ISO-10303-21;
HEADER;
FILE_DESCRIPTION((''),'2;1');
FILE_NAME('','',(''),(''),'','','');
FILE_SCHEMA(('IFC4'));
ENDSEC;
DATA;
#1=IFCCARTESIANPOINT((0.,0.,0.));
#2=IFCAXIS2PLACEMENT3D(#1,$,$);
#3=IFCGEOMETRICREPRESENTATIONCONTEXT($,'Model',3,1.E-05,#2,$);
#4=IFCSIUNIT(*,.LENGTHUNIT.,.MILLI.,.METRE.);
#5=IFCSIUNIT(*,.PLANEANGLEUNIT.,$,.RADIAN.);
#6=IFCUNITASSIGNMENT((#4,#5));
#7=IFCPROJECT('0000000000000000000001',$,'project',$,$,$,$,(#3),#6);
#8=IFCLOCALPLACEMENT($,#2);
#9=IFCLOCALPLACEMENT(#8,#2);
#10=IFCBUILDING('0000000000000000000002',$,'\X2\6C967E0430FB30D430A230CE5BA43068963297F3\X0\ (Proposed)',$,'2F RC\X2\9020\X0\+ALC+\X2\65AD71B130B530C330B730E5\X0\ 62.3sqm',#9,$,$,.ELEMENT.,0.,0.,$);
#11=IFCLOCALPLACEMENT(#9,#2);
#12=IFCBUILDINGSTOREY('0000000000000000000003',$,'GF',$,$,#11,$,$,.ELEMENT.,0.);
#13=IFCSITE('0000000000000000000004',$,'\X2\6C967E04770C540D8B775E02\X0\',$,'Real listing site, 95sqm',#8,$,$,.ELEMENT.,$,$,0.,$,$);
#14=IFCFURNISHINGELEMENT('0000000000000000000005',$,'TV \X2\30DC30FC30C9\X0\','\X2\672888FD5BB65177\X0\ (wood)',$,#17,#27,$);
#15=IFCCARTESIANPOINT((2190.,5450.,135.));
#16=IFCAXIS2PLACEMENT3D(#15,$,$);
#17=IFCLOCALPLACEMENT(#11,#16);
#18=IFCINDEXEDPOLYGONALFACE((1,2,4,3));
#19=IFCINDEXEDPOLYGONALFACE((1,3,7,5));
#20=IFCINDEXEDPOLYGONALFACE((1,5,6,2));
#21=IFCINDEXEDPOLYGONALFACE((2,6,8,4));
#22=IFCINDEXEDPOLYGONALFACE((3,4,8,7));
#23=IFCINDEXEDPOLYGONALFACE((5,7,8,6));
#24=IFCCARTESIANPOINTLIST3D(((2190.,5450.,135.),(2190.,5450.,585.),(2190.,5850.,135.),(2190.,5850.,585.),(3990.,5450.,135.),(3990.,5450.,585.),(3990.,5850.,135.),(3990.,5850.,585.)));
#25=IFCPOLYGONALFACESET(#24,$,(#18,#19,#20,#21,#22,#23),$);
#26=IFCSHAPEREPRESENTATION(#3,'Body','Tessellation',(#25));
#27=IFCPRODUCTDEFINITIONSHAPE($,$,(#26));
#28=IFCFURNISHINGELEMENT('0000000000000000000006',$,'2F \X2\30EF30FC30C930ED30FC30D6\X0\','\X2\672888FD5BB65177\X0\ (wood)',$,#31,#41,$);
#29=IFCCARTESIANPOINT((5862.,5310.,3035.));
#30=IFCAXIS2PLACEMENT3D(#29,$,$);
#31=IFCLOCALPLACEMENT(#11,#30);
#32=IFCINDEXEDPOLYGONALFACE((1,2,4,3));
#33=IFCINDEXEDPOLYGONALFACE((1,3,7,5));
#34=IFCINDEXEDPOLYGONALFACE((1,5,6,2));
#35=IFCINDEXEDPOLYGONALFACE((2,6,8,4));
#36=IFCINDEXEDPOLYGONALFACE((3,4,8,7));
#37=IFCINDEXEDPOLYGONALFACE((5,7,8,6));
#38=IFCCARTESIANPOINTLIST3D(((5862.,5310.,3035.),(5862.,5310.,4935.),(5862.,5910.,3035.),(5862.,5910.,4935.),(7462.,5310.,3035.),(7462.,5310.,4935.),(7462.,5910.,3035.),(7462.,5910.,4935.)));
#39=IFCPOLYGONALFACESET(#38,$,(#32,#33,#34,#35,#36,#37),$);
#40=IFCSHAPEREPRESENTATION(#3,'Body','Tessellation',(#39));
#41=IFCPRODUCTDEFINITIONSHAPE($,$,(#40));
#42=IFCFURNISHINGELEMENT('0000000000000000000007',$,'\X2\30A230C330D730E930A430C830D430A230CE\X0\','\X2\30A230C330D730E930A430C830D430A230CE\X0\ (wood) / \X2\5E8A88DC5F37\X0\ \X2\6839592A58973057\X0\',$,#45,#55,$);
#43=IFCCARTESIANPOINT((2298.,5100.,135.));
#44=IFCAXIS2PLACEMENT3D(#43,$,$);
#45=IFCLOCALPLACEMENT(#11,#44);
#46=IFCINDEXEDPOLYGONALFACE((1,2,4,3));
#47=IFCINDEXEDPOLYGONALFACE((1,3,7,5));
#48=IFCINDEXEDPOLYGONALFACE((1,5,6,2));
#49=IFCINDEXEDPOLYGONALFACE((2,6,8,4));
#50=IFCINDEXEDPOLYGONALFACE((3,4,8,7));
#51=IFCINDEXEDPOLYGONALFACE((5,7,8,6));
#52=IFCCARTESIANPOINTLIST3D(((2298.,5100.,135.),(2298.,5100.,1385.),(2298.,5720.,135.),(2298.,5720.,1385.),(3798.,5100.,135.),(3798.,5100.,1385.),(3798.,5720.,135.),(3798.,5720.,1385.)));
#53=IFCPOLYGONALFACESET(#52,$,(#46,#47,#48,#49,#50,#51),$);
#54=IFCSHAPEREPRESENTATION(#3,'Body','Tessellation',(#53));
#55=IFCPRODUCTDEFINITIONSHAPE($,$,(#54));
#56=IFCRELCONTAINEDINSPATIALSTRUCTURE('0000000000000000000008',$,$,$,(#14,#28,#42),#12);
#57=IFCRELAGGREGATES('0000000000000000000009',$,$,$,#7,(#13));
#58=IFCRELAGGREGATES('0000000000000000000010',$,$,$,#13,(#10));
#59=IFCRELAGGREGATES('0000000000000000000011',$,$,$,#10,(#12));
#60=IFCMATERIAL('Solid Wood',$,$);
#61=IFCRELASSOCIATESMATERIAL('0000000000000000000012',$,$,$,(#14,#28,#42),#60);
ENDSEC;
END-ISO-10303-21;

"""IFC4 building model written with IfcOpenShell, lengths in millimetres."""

from ifc_helpers import new_model, si_unit, frame, frame_2d, origin, place, context, project, spatial, rectangle, extrude, material, element, save


model = new_model("IFC4")

# Units and contexts
model_context = context("Model", 3, precision=1e-05, world=origin())
ifc_project = project(units=[si_unit("LENGTHUNIT", "METRE", prefix="MILLI"), si_unit("PLANEANGLEUNIT", "RADIAN")], contexts=[model_context])

# Site, building, storey
site_placement = place(None, origin())
site = spatial("IfcSite", under=ifc_project, at=site_placement, Name="沖縄県名護市", ObjectType="Real listing site, 95sqm", CompositionType="ELEMENT", RefElevation=0.0)
building_placement = place(site_placement, origin())
building = spatial("IfcBuilding", under=site, at=building_placement, Name="沖縄・ピアノ室と防音 (Proposed)", ObjectType="2F RC造+ALC+断熱サッシュ 62.3sqm", CompositionType="ELEMENT", ElevationOfRefHeight=0.0, ElevationOfTerrain=0.0)
storey_placement = place(building_placement, origin())
storey = spatial("IfcBuildingStorey", under=building, at=storey_placement, Name="GF", CompositionType="ELEMENT", Elevation=0.0)

# Shared definitions
ifc_material_1 = material(Name="Solid Wood")

# Furnishing elements
furnishing_1_placement = place(storey_placement, frame((2190.0, 5450.0, 135.0)))
element("IfcFurnishingElement", 1, at=furnishing_1_placement, inside=storey, material=ifc_material_1, Name="TV ボード", Description="木製家具 (wood)", context=model_context, shape_type="SweptSolid", body=[
    extrude(rectangle(XDim=1800.0, YDim=400.0, at=frame_2d((900.0, 200.0))), frame((2190.0, 5450.0, 135.0)), (0.0, 0.0, 1.0), 450.0),
])
furnishing_2_placement = place(storey_placement, frame((5862.0, 5310.0, 3035.0)))
element("IfcFurnishingElement", 2, at=furnishing_2_placement, inside=storey, material=ifc_material_1, Name="2F ワードローブ", Description="木製家具 (wood)", context=model_context, shape_type="SweptSolid", body=[
    extrude(rectangle(XDim=1600.0, YDim=600.0, at=frame_2d((800.0, 300.0))), frame((5862.0, 5310.0, 3035.0)), (0.0, 0.0, 1.0), 1900.0),
])
furnishing_3_placement = place(storey_placement, frame((2298.0, 5100.0, 135.0)))
element("IfcFurnishingElement", 3, at=furnishing_3_placement, inside=storey, material=ifc_material_1, Name="アップライトピアノ", Description="アップライトピアノ (wood) / 床補強 根太増し", context=model_context, shape_type="SweptSolid", body=[
    extrude(rectangle(XDim=1500.0, YDim=620.0, at=frame_2d((750.0, 310.0))), frame((2298.0, 5100.0, 135.0)), (0.0, 0.0, 1.0), 1250.0),
])

save(model, "model.ifc")
